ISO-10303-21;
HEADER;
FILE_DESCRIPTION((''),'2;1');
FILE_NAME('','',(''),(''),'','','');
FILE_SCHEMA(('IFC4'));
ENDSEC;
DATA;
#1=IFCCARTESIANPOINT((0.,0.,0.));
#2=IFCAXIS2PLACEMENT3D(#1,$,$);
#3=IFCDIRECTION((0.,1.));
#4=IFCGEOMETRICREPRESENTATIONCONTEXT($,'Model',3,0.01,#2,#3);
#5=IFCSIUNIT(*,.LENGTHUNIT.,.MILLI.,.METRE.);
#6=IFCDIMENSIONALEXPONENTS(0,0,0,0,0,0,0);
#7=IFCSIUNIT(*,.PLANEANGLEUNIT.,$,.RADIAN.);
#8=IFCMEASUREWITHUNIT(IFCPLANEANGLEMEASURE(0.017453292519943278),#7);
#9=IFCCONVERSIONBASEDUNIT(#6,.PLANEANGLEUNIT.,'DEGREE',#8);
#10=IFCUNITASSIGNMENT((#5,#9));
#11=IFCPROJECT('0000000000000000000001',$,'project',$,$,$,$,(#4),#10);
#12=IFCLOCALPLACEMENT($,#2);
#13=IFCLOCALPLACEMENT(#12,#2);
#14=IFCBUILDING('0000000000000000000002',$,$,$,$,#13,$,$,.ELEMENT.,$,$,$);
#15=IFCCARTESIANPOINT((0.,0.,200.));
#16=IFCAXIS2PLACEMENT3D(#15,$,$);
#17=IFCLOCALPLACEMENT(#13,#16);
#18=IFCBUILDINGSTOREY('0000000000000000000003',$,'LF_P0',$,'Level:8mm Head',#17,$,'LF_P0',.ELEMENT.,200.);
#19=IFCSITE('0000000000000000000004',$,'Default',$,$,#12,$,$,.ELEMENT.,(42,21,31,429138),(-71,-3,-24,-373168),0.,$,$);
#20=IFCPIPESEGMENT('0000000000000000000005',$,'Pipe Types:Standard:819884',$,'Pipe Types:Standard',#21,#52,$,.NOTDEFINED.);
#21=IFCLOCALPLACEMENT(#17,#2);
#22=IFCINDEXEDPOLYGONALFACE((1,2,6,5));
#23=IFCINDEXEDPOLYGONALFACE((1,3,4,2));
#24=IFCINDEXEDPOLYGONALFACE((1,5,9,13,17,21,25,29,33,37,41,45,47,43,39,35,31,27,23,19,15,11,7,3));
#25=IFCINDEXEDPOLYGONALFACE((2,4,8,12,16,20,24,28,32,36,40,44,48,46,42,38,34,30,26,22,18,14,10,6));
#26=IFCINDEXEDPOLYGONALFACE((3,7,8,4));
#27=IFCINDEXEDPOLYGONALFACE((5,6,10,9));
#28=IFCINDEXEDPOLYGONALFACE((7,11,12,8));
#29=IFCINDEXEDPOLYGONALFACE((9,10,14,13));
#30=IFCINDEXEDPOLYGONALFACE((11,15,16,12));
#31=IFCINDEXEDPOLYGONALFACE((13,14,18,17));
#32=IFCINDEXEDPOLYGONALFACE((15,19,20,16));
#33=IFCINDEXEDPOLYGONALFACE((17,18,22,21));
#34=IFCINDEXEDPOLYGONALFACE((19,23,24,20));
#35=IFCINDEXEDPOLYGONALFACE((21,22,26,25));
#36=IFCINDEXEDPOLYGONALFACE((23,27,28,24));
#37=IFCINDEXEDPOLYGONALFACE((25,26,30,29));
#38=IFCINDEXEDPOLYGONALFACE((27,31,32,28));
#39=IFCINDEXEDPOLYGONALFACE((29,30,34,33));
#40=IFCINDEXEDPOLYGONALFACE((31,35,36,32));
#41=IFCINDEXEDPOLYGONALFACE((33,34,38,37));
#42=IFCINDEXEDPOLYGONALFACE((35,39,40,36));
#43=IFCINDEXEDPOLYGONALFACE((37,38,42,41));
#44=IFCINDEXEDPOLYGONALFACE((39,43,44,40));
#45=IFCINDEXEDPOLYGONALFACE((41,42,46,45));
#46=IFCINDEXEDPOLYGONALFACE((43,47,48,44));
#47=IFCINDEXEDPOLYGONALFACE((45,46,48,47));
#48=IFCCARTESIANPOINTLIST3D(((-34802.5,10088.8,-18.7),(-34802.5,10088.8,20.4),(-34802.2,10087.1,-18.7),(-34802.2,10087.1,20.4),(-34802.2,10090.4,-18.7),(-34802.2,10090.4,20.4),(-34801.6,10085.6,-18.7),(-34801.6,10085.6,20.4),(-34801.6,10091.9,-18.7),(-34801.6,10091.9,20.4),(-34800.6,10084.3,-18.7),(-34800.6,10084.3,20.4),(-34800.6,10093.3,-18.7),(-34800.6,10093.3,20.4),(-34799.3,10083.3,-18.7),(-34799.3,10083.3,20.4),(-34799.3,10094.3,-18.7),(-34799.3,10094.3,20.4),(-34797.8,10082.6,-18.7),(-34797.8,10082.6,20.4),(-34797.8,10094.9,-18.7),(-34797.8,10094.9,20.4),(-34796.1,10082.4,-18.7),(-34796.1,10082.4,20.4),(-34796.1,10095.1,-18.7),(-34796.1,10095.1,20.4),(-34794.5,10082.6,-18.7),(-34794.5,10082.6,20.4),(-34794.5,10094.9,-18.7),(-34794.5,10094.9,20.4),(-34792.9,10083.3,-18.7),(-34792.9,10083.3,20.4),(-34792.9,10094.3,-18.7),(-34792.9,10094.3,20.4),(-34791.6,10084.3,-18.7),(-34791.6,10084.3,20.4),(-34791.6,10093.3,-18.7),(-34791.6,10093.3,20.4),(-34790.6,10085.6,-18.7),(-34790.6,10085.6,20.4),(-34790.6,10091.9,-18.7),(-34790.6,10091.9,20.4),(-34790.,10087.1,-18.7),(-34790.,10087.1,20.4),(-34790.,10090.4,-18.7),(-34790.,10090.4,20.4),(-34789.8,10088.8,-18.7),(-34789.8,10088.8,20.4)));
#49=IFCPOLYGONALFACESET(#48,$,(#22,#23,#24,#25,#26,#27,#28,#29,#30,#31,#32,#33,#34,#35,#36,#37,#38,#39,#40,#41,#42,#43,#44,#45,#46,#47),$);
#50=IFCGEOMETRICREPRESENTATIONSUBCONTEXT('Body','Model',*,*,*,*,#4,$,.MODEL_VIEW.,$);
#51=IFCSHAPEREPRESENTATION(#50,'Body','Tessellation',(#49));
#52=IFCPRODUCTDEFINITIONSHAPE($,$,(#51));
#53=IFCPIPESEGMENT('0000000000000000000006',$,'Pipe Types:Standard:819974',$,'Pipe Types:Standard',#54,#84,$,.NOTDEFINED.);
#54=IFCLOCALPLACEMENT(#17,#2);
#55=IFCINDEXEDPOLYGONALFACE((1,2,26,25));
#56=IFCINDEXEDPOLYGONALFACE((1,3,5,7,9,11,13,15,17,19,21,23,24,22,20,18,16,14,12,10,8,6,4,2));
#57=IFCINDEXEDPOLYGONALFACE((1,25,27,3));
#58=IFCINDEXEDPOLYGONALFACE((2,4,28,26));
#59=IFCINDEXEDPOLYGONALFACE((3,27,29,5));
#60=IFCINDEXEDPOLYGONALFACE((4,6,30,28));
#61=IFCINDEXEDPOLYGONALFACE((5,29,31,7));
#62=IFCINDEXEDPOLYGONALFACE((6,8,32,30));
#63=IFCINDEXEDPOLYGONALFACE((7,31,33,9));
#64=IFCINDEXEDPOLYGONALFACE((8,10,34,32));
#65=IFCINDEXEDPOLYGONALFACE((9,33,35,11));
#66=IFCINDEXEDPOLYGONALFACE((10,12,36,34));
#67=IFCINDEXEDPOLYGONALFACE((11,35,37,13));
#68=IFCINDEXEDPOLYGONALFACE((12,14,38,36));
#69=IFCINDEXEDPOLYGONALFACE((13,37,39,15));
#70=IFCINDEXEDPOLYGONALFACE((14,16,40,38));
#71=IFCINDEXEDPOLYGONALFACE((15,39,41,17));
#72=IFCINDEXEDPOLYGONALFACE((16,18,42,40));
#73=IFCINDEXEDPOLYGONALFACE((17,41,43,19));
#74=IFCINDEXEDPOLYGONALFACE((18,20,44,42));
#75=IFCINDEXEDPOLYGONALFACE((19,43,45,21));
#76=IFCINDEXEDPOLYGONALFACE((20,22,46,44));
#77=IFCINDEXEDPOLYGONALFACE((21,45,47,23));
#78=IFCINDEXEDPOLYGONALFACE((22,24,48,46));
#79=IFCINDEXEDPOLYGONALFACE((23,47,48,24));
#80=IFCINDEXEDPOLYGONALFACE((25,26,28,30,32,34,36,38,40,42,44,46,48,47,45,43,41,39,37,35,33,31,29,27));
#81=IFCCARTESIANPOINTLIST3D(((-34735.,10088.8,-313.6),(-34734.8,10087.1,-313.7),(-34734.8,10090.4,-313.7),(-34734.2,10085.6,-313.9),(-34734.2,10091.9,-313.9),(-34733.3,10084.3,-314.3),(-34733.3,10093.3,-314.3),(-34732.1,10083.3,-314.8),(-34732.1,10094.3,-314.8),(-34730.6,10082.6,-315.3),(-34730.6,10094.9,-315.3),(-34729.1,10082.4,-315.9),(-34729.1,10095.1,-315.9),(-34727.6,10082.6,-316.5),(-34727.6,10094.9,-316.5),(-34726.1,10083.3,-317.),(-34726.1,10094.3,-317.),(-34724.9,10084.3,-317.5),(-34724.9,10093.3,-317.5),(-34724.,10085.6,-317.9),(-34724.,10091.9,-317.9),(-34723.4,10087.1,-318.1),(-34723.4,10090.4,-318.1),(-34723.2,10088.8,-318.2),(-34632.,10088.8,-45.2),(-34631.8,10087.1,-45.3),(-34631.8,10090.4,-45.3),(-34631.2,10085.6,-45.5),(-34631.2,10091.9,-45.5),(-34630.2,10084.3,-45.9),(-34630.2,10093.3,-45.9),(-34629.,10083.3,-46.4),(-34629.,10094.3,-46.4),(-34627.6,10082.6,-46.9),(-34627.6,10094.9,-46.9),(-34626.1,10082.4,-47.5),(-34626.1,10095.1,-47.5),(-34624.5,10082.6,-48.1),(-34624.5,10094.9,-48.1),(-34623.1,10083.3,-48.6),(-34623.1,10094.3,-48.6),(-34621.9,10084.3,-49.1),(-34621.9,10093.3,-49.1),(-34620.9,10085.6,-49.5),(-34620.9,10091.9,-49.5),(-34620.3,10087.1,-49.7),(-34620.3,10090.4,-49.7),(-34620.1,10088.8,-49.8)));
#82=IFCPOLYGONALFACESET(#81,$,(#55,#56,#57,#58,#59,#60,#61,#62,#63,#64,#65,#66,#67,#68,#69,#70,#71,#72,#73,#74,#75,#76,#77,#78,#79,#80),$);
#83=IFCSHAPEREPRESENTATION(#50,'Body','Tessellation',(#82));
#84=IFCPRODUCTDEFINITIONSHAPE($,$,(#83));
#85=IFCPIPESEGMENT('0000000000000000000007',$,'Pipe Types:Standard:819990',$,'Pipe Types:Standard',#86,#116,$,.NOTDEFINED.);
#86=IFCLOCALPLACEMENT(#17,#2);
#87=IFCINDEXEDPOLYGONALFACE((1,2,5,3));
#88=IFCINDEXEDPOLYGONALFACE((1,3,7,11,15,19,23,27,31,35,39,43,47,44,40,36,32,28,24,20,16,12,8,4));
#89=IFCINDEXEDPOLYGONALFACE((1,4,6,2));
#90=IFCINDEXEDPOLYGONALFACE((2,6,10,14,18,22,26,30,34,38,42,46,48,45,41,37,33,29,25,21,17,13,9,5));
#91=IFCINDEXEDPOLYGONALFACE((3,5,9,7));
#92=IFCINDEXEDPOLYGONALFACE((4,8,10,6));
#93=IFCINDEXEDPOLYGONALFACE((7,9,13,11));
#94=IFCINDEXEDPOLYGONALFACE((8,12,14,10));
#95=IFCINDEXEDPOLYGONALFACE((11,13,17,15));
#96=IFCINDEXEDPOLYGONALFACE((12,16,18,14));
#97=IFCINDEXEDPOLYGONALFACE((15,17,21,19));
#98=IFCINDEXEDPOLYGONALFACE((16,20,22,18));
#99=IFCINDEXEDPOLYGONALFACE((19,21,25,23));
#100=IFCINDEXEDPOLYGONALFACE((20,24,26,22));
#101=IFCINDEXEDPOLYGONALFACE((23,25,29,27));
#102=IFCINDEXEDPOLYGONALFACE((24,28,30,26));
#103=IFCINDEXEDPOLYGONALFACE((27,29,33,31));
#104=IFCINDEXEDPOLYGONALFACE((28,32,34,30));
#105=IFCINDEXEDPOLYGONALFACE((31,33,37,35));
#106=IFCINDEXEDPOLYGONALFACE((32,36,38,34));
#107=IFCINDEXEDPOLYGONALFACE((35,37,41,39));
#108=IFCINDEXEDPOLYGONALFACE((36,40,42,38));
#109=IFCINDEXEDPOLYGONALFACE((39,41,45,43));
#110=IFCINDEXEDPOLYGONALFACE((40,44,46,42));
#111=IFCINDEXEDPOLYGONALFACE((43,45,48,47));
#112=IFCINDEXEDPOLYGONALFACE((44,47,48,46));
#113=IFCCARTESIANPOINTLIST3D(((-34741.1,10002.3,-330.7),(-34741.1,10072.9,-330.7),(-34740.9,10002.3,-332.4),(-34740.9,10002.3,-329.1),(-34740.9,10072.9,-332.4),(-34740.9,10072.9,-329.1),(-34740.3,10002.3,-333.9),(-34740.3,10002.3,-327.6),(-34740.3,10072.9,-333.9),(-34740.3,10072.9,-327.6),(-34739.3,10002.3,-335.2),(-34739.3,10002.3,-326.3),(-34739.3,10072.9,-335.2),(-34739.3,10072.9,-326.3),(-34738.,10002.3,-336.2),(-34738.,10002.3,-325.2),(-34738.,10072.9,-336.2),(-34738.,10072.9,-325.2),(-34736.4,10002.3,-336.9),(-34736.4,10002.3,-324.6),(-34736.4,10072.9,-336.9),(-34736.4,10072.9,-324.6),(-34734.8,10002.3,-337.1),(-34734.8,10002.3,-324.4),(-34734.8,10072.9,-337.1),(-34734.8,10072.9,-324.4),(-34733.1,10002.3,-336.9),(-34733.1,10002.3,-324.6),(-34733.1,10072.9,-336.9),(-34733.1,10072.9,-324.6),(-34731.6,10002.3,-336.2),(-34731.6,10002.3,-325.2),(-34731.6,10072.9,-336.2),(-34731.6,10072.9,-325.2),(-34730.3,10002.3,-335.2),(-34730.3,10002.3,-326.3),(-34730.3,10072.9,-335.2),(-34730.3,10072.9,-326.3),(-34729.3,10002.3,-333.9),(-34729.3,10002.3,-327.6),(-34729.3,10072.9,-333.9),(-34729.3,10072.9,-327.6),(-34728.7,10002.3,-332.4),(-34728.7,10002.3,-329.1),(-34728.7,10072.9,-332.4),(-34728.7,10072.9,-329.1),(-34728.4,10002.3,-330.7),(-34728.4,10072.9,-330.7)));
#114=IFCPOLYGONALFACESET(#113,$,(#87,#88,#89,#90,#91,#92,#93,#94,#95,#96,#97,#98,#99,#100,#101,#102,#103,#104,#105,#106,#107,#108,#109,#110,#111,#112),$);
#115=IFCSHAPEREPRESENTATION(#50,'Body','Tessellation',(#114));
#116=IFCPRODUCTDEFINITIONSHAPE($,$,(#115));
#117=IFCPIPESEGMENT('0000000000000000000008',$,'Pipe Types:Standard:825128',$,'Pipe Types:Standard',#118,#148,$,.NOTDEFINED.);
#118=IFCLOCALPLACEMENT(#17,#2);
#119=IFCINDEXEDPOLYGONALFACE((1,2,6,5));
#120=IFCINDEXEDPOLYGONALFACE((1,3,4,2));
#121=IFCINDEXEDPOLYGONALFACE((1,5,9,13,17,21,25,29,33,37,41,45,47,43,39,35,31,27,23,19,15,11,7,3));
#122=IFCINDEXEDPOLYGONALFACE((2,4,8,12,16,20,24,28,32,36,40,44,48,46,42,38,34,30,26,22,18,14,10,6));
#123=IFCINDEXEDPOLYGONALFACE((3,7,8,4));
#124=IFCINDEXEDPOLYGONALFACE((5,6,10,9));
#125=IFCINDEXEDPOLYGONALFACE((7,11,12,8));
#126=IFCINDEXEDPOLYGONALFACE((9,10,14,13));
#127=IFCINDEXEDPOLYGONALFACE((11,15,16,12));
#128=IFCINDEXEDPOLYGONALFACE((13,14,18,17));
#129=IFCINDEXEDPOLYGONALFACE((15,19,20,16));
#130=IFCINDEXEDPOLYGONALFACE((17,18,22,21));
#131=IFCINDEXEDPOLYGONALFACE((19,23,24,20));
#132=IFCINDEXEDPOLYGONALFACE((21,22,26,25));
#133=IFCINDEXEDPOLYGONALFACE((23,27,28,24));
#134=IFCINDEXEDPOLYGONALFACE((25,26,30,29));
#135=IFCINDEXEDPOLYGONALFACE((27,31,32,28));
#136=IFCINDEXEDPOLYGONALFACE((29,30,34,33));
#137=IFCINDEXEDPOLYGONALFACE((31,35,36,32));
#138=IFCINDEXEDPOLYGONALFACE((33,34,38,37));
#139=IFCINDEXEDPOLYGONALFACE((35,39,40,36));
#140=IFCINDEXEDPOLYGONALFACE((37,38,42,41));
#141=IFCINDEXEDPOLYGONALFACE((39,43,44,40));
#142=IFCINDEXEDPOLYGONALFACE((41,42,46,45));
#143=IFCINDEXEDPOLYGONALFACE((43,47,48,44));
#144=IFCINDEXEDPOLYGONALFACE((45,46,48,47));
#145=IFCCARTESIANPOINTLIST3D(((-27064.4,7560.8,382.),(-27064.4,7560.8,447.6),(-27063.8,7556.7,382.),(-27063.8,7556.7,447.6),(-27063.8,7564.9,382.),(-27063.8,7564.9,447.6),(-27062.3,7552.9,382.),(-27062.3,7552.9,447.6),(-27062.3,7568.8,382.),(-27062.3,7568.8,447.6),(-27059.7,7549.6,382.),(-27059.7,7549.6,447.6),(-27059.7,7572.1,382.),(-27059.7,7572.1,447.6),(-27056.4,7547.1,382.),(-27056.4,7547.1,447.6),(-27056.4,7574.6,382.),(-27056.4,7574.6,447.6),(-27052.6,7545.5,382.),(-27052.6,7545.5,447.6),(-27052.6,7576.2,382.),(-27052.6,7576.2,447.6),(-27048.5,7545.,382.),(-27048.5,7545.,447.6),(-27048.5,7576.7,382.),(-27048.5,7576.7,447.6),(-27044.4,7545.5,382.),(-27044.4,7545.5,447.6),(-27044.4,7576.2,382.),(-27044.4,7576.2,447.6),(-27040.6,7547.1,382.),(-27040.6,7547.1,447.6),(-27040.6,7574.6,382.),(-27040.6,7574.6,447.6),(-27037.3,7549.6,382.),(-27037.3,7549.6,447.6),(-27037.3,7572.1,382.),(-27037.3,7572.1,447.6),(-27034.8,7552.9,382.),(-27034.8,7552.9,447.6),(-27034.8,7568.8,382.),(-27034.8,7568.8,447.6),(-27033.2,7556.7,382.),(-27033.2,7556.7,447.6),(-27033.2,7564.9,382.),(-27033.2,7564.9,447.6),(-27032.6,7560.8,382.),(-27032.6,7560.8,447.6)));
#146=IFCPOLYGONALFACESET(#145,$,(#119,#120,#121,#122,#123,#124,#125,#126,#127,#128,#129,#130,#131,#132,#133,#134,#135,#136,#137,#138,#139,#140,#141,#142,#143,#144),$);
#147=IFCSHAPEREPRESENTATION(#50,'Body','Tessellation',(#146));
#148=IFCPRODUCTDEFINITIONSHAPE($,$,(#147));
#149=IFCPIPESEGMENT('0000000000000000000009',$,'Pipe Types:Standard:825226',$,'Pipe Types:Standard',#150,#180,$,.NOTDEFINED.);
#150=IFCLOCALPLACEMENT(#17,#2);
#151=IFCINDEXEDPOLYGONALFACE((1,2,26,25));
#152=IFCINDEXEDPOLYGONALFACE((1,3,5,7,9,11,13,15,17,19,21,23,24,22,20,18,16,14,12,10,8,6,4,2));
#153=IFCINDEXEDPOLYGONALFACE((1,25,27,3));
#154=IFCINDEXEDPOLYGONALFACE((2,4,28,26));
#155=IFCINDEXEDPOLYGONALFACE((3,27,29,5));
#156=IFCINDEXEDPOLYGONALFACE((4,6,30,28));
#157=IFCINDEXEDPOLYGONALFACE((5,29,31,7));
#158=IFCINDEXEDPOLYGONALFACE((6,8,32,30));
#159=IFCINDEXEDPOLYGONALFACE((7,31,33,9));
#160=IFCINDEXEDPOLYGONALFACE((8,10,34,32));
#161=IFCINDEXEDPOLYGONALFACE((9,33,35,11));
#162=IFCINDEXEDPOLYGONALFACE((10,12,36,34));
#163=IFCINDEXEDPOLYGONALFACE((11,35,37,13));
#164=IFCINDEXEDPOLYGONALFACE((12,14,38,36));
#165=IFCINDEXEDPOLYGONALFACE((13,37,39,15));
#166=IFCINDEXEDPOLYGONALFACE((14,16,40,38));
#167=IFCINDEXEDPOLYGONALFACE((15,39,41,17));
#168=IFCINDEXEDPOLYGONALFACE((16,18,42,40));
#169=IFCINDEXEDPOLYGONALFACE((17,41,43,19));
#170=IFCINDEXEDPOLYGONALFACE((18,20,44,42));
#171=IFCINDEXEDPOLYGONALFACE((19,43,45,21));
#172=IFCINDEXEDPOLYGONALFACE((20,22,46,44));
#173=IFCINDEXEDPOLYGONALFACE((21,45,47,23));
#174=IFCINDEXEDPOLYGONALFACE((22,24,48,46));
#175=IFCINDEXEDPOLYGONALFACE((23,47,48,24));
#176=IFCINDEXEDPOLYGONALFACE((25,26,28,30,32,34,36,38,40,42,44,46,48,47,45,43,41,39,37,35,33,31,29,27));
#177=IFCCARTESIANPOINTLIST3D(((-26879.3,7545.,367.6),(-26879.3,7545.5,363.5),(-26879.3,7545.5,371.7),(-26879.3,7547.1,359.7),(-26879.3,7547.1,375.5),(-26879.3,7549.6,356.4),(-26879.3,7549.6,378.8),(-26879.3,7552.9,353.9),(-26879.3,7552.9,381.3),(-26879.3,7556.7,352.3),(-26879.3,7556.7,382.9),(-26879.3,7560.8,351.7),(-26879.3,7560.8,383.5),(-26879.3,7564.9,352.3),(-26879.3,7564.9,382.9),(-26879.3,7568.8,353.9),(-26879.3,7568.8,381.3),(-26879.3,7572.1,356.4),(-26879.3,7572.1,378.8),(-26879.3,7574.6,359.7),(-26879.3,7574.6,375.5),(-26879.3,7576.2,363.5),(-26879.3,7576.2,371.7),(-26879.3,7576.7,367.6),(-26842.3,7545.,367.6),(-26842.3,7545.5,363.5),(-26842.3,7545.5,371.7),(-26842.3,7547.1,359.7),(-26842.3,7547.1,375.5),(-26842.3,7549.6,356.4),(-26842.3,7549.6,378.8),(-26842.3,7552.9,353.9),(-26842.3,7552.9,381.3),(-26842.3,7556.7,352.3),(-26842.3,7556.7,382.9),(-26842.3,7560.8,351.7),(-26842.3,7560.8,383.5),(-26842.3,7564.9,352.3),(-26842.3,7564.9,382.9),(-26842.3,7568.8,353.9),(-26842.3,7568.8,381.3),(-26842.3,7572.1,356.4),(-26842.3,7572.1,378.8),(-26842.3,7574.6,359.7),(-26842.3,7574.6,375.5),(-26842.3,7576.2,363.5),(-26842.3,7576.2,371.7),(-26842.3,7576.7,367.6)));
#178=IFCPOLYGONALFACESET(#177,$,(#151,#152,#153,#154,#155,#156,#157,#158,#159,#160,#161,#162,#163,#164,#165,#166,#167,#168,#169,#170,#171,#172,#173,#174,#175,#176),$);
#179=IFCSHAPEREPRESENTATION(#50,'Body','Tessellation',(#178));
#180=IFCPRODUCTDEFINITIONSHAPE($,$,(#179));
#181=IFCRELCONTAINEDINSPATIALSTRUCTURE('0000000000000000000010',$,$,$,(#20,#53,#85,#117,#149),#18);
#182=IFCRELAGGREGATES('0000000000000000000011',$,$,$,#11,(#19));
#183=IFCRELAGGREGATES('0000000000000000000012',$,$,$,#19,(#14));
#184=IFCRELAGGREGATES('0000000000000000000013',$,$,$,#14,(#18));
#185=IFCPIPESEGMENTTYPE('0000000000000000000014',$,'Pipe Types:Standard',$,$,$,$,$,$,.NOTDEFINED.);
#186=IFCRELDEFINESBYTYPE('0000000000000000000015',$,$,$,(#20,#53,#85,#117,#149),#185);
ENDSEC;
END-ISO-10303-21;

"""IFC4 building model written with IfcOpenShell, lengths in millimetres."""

from ifc_helpers import new_model, entity, si_unit, converted_unit, direction, frame, origin, place, context, subcontext, project, spatial, arc, indexed_curve, outline, extrude, type_object, element, save


model = new_model("IFC4")

# Units and contexts
model_context = context("Model", 3, precision=0.01, world=origin(), true_north=direction((0.0, 1.0)))
body_context = subcontext(model_context, "Body", "Model", "MODEL_VIEW")
ifc_project = project(units=[si_unit("LENGTHUNIT", "METRE", prefix="MILLI"), converted_unit("PLANEANGLEUNIT", "DEGREE", entity("IfcPlaneAngleMeasure", 0.017453292519943278), si_unit("PLANEANGLEUNIT", "RADIAN"), dimensions=[0, 0, 0, 0, 0, 0, 0])], contexts=[model_context])

# Site, building, storey
site_placement = place(None, origin())
site = spatial("IfcSite", under=ifc_project, at=site_placement, Name="Default", CompositionType="ELEMENT", RefLatitude=(42, 21, 31, 429138), RefLongitude=(-71, -3, -24, -373168), RefElevation=0.0)
building_placement = place(site_placement, origin())
building = spatial("IfcBuilding", under=site, at=building_placement, CompositionType="ELEMENT")
storey_placement = place(building_placement, frame((0.0, 0.0, 200.0)))
storey = spatial("IfcBuildingStorey", under=building, at=storey_placement, Name="LF_P0", ObjectType="Level:8mm Head", LongName="LF_P0", CompositionType="ELEMENT", Elevation=200.0)

# Pipe segments
pipe_segment_type_1 = type_object("IfcPipeSegmentType", Name="Pipe Types:Standard", PredefinedType="NOTDEFINED")
pipe_segment_1_placement = place(storey_placement, origin())
element("IfcPipeSegment", 1, at=pipe_segment_1_placement, inside=storey, type_object=pipe_segment_type_1, Name="Pipe Types:Standard:819884", ObjectType="Pipe Types:Standard", PredefinedType="NOTDEFINED", context=body_context, shape_type="SweptSolid", body=[
    extrude(outline(indexed_curve([(6.3, 0.0), (4.5, 4.5), (0.0, 6.4), (-4.5, 4.5), (-6.3, 0.0), (-4.5, -4.5), (0.0, -6.3), (4.5, -4.5)], segments=[arc(1, 2, 3), arc(3, 4, 5), arc(5, 6, 7), arc(7, 8, 1)], self_intersect=False)), frame((-34796.1, 10088.8, -18.7), z_axis=(0.0, 0.0, 1.0), x_axis=(-1.0, 0.0, 0.0)), (0.0, 0.0, 1.0), 39.1),
])
pipe_segment_2_placement = place(storey_placement, origin())
element("IfcPipeSegment", 2, at=pipe_segment_2_placement, inside=storey, type_object=pipe_segment_type_1, Name="Pipe Types:Standard:819974", ObjectType="Pipe Types:Standard", PredefinedType="NOTDEFINED", context=body_context, shape_type="SweptSolid", body=[
    extrude(outline(indexed_curve([(6.4, 0.0), (4.5, 4.5), (0.0, 6.4), (-4.5, 4.5), (-6.4, 0.0), (-4.5, -4.5), (0.0, -6.3), (4.5, -4.5)], segments=[arc(1, 2, 3), arc(3, 4, 5), arc(5, 6, 7), arc(7, 8, 1)], self_intersect=False)), frame((-34729.1, 10088.8, -315.9), z_axis=(0.358368, 0.0, 0.93358), x_axis=(0.0, -1.0, 0.0)), (0.0, 0.0, 1.0), 287.5),
])
pipe_segment_3_placement = place(storey_placement, origin())
element("IfcPipeSegment", 3, at=pipe_segment_3_placement, inside=storey, type_object=pipe_segment_type_1, Name="Pipe Types:Standard:819990", ObjectType="Pipe Types:Standard", PredefinedType="NOTDEFINED", context=body_context, shape_type="SweptSolid", body=[
    extrude(outline(indexed_curve([(6.3, 0.0), (4.5, 4.5), (0.0, 6.3), (-4.5, 4.5), (-6.4, 0.0), (-4.5, -4.5), (0.0, -6.3), (4.5, -4.5)], segments=[arc(1, 2, 3), arc(3, 4, 5), arc(5, 6, 7), arc(7, 8, 1)], self_intersect=False)), frame((-34734.8, 10002.3, -330.7), z_axis=(0.0, 1.0, 0.0), x_axis=(1.0, 0.0, 0.0)), (0.0, 0.0, 1.0), 70.5),
])
pipe_segment_4_placement = place(storey_placement, origin())
element("IfcPipeSegment", 4, at=pipe_segment_4_placement, inside=storey, type_object=pipe_segment_type_1, Name="Pipe Types:Standard:825128", ObjectType="Pipe Types:Standard", PredefinedType="NOTDEFINED", context=body_context, shape_type="SweptSolid", body=[
    extrude(outline(indexed_curve([(15.9, 0.0), (11.2, 11.2), (0.0, 15.9), (-11.2, 11.2), (-15.9, 0.0), (-11.2, -11.2), (0.0, -15.9), (11.2, -11.2)], segments=[arc(1, 2, 3), arc(3, 4, 5), arc(5, 6, 7), arc(7, 8, 1)], self_intersect=False)), frame((-27048.5, 7560.8, 382.0)), (0.0, 0.0, 1.0), 65.6),
])
pipe_segment_5_placement = place(storey_placement, origin())
element("IfcPipeSegment", 5, at=pipe_segment_5_placement, inside=storey, type_object=pipe_segment_type_1, Name="Pipe Types:Standard:825226", ObjectType="Pipe Types:Standard", PredefinedType="NOTDEFINED", context=body_context, shape_type="SweptSolid", body=[
    extrude(outline(indexed_curve([(15.9, 0.0), (11.2, 11.2), (0.0, 15.9), (-11.2, 11.2), (-15.9, 0.0), (-11.2, -11.2), (0.0, -15.9), (11.2, -11.2)], segments=[arc(1, 2, 3), arc(3, 4, 5), arc(5, 6, 7), arc(7, 8, 1)], self_intersect=False)), frame((-26879.3, 7560.8, 367.6), z_axis=(1.0, 0.0, 0.0), x_axis=(0.0, -1.0, 0.0)), (0.0, 0.0, 1.0), 37.0),
])

save(model, "model.ifc")
